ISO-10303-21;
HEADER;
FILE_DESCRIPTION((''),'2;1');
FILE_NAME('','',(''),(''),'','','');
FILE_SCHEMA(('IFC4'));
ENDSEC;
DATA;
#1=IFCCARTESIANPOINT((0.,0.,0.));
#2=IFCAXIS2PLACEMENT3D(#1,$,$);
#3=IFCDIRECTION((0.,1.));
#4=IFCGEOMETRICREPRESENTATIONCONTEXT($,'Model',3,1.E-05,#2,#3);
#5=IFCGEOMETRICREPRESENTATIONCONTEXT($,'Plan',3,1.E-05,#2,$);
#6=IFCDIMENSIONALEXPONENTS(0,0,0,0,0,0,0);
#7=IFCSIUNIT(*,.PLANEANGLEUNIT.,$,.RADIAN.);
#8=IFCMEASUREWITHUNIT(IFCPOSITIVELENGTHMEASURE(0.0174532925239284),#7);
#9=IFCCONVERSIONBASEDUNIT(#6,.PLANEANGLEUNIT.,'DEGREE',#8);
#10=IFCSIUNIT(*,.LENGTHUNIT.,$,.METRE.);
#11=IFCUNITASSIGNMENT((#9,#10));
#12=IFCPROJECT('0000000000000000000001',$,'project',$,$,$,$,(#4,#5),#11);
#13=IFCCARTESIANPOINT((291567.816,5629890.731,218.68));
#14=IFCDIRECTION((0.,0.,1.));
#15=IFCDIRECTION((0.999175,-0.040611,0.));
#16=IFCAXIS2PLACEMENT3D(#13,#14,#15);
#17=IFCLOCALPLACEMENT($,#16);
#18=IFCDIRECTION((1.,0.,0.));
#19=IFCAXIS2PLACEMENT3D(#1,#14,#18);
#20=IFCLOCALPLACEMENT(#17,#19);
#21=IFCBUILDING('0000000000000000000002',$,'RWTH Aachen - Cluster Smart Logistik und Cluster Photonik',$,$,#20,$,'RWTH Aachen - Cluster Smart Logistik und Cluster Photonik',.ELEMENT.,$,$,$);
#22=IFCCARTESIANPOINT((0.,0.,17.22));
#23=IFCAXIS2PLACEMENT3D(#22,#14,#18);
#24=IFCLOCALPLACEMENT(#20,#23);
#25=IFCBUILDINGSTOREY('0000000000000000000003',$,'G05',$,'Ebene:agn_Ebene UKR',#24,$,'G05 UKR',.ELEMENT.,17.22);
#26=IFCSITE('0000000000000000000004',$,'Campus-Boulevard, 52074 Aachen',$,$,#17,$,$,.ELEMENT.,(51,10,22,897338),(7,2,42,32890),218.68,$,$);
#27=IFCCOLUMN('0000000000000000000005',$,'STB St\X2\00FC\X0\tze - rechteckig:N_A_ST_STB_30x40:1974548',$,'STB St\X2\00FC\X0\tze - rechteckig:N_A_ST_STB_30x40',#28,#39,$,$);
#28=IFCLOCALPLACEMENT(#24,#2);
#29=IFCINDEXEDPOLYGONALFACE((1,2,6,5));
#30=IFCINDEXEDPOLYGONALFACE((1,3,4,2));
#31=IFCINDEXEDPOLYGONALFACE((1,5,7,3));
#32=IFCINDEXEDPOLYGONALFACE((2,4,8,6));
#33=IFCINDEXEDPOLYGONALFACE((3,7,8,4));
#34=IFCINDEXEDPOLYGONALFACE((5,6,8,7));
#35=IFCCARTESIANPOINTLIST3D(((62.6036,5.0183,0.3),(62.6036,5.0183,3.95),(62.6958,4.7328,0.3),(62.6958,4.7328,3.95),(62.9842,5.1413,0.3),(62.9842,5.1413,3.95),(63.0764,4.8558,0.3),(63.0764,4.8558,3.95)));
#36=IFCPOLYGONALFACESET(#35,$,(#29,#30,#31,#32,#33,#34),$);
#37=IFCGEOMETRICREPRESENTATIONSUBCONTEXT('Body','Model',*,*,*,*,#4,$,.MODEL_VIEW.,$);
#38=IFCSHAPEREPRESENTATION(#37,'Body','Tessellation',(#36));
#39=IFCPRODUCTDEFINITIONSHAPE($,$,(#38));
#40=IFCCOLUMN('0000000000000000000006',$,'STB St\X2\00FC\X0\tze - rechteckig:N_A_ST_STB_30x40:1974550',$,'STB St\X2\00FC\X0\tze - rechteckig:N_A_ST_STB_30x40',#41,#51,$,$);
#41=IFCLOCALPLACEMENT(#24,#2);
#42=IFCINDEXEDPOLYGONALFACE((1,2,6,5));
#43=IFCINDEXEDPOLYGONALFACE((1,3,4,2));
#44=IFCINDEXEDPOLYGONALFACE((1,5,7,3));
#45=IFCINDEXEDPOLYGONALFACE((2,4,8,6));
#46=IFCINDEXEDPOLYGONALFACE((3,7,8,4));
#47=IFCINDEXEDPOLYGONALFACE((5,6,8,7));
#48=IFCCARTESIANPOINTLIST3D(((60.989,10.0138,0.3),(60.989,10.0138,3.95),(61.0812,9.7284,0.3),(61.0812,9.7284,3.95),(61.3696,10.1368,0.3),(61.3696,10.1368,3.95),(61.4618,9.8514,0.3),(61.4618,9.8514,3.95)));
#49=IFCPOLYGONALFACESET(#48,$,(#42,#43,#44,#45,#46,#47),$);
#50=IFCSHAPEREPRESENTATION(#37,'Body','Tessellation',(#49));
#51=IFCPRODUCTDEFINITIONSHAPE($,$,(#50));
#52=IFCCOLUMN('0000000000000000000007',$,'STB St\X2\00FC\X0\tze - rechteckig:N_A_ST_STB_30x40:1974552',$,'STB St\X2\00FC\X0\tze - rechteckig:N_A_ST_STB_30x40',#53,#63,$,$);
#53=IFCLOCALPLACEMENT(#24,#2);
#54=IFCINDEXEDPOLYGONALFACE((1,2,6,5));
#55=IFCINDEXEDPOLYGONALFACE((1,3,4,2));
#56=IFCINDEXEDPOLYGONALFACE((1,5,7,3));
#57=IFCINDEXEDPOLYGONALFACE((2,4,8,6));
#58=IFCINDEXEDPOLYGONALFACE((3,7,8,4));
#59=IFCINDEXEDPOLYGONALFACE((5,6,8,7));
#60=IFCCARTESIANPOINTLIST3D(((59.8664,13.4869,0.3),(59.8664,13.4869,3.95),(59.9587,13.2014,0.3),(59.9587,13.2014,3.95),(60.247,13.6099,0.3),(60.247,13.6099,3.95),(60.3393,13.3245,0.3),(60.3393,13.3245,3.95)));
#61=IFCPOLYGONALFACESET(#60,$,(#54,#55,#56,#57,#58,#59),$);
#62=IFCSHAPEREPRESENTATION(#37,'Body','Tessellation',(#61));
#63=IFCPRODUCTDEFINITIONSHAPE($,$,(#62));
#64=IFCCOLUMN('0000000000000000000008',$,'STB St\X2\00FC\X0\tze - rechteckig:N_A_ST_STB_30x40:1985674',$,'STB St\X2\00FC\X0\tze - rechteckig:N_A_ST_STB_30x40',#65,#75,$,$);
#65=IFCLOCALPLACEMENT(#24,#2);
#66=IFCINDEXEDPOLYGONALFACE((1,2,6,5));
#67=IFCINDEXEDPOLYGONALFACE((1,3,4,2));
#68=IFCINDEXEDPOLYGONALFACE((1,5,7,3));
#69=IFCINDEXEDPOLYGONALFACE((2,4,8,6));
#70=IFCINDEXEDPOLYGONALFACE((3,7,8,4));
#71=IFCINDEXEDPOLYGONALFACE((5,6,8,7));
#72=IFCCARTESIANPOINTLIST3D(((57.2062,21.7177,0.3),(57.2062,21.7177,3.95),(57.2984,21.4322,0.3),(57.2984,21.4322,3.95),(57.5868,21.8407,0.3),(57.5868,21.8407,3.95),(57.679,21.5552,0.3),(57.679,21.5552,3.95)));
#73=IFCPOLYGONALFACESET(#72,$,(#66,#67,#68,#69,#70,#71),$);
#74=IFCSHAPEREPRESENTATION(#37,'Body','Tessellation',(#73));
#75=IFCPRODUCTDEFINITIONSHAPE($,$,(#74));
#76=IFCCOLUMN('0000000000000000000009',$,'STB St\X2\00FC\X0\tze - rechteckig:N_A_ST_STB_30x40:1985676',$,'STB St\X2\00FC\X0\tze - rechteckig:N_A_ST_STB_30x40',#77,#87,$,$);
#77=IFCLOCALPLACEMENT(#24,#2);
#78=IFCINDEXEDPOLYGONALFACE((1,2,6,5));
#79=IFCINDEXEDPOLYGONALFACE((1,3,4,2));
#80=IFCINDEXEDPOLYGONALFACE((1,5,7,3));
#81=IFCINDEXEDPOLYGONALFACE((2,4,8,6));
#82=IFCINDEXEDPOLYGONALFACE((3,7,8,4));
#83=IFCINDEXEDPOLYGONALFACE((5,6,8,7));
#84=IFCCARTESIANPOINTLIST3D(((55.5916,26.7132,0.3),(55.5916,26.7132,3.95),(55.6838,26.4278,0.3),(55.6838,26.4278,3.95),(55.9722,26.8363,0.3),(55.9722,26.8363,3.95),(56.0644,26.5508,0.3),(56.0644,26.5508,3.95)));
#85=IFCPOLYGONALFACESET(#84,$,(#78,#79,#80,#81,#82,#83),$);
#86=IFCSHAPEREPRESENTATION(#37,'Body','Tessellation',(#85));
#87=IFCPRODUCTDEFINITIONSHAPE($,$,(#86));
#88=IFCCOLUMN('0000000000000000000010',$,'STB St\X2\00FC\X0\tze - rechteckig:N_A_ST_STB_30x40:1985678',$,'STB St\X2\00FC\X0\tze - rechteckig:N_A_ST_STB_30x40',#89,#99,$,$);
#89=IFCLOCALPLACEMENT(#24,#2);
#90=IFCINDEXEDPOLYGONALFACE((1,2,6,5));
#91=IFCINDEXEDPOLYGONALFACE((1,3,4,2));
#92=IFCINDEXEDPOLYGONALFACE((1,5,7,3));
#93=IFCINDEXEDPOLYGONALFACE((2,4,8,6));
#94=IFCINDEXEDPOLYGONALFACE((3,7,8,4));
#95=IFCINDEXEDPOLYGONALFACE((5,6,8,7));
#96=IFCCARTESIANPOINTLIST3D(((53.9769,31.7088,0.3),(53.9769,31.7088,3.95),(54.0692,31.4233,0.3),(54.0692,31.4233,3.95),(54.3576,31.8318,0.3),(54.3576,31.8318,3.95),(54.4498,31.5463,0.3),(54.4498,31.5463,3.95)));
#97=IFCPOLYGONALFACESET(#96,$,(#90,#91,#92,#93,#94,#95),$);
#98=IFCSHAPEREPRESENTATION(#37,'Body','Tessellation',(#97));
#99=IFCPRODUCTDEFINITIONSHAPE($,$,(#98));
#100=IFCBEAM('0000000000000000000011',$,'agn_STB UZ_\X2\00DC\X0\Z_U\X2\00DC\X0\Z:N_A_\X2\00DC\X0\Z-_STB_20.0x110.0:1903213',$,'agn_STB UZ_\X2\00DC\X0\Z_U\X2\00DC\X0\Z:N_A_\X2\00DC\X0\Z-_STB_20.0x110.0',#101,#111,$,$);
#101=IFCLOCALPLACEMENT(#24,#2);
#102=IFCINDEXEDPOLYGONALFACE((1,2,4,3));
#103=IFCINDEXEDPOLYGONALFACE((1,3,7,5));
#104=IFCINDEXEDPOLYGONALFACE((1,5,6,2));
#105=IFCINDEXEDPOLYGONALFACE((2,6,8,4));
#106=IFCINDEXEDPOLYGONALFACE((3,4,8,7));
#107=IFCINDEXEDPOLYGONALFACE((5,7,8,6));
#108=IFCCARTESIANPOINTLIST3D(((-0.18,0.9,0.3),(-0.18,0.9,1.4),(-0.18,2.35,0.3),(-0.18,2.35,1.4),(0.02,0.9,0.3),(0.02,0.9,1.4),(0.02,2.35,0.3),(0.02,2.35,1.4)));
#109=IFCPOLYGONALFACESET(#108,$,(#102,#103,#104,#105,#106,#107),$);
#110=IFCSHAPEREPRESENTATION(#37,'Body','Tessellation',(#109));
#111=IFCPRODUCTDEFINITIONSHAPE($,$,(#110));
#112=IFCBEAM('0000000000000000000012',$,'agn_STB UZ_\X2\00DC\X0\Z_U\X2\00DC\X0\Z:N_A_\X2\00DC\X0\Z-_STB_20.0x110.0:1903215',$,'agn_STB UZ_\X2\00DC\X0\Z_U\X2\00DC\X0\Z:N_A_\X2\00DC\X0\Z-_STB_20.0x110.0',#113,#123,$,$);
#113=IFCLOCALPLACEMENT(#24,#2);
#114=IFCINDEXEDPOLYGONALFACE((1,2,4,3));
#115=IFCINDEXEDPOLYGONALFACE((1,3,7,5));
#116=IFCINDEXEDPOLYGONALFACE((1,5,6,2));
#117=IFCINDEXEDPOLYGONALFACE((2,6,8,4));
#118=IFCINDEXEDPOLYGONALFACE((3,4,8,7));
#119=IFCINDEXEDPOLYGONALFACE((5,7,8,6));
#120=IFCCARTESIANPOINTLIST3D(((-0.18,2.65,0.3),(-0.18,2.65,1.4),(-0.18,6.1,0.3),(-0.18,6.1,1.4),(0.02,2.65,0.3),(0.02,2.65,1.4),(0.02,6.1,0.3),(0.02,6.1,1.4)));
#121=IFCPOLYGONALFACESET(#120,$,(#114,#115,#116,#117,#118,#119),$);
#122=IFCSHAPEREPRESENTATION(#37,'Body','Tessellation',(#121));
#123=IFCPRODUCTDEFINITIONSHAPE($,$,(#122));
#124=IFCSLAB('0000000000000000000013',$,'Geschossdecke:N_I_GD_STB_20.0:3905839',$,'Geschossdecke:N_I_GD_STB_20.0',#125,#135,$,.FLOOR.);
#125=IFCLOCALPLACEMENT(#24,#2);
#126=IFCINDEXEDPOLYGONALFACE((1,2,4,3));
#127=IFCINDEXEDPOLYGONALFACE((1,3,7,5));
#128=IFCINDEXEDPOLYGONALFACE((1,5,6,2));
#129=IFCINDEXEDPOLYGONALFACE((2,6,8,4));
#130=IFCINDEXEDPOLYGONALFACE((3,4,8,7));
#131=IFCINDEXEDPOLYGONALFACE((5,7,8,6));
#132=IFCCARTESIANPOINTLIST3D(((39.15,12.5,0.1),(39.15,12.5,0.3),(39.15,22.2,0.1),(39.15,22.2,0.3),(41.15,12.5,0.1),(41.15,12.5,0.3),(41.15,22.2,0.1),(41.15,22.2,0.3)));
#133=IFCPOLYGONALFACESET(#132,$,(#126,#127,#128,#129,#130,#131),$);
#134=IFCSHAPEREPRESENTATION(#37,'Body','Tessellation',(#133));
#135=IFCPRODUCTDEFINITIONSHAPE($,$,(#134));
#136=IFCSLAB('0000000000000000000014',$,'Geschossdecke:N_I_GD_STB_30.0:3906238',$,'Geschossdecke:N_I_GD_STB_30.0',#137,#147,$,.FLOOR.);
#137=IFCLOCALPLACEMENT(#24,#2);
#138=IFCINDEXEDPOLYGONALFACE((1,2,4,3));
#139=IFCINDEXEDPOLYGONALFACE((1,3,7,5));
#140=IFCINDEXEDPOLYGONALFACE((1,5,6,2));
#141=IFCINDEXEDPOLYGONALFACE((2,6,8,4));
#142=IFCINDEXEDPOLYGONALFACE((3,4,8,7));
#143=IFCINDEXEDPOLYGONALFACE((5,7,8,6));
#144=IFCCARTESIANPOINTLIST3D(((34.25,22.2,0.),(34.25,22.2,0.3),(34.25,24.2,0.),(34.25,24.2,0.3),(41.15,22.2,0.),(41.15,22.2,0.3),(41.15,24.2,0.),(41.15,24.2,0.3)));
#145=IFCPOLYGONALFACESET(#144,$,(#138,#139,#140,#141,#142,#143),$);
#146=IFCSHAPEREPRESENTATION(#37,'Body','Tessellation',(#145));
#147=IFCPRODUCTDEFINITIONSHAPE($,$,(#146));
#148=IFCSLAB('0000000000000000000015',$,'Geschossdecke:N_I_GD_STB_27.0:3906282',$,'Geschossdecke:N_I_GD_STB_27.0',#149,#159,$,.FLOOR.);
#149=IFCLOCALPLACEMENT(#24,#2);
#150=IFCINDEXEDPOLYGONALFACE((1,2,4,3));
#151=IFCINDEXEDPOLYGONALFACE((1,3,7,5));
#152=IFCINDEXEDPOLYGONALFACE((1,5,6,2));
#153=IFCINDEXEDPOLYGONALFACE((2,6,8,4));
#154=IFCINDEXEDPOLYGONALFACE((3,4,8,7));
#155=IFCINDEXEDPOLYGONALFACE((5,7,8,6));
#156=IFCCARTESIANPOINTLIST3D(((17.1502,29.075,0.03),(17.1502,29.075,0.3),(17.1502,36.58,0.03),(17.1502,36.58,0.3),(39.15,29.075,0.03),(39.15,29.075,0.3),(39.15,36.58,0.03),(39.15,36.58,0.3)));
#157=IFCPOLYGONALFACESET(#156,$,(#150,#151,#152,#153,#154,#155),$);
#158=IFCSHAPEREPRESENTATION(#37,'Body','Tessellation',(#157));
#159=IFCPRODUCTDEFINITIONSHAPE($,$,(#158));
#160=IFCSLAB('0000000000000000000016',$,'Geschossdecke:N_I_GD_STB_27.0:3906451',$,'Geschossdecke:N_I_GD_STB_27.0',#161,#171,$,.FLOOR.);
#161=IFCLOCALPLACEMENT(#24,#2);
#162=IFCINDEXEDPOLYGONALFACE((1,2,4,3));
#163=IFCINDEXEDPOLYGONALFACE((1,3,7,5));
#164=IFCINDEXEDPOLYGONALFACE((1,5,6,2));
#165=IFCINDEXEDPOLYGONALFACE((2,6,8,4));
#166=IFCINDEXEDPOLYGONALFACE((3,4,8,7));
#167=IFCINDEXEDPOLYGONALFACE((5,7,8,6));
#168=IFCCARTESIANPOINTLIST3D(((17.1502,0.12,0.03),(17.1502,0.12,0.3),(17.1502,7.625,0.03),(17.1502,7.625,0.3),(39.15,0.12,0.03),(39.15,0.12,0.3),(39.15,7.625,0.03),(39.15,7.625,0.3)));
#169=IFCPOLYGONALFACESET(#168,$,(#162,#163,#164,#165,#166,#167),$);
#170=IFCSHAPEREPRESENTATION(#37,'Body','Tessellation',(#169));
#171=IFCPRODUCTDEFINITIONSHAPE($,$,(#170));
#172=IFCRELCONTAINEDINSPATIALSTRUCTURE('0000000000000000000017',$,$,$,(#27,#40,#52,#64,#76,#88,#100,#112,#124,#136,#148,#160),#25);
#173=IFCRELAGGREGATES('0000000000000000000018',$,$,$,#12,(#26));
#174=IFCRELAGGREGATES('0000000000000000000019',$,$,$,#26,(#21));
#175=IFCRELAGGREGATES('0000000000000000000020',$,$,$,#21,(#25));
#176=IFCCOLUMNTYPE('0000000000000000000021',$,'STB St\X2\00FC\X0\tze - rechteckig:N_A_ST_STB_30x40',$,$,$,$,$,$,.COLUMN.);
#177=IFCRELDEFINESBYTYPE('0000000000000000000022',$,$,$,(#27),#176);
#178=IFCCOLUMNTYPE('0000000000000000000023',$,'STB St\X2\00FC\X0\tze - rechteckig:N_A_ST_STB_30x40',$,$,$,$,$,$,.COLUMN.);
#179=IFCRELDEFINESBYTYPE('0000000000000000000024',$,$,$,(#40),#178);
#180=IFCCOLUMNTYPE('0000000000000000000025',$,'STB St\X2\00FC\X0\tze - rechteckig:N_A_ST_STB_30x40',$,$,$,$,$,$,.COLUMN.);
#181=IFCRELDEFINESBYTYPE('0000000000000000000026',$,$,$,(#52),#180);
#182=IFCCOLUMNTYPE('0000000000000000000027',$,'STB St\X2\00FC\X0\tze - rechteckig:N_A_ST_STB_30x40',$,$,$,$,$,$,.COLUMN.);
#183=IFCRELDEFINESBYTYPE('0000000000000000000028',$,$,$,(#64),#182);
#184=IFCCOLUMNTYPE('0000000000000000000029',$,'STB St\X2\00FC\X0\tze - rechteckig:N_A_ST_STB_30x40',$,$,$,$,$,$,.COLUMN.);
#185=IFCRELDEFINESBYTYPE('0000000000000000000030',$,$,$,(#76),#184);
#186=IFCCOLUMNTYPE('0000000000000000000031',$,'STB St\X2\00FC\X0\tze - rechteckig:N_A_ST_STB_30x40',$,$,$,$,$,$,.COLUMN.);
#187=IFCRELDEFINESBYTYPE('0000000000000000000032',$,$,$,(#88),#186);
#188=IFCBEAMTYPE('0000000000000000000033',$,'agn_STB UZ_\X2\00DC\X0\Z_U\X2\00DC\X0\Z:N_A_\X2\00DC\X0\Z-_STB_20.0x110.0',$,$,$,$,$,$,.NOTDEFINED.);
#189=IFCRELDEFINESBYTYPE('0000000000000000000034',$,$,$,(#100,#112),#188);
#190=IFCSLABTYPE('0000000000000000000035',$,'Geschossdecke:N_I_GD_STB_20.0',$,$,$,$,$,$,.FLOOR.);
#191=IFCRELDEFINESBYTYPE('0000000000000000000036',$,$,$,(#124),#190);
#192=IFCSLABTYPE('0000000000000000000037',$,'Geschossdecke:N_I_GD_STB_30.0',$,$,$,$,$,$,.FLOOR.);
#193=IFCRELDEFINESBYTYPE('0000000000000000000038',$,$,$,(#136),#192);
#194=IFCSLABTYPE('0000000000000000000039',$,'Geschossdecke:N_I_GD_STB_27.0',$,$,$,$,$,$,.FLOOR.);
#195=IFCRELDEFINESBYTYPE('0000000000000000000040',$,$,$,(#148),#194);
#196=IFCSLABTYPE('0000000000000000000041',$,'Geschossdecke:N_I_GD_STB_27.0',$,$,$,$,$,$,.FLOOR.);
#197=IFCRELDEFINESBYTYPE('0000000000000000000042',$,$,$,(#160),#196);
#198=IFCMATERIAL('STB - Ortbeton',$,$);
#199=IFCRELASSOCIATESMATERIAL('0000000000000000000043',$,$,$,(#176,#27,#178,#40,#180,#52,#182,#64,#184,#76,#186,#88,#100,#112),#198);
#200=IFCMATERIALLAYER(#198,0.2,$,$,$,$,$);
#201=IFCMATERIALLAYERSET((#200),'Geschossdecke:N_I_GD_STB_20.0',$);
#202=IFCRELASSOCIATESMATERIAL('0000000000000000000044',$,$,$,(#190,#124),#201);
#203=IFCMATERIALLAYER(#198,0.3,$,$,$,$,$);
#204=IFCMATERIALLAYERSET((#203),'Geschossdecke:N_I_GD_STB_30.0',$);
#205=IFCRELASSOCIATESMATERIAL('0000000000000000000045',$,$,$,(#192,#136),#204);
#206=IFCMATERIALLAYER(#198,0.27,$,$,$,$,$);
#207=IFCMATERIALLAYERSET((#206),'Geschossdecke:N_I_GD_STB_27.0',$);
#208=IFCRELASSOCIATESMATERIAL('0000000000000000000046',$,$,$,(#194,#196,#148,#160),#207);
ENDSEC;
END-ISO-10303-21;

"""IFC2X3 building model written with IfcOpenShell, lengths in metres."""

from ifc_helpers import new_model, entity, si_unit, converted_unit, direction, frame, frame_2d, origin, origin_with_axes, origin_2d_with_axis, place, context, subcontext, project, spatial, rectangle, extrude, source, transform, mapped, material, layer, layer_set, layer_usage, type_object, element, save


model = new_model("IFC2X3")

# Units and contexts
model_context = context("Model", 3, precision=1e-05, world=origin(), true_north=direction((0.0, 1.0)))
plan_context = context("Plan", 3, precision=1e-05, world=origin())
body_context = subcontext(model_context, "Body", "Model", "MODEL_VIEW")
ifc_project = project(units=[converted_unit("PLANEANGLEUNIT", "DEGREE", entity("IfcPositiveLengthMeasure", 0.0174532925239284), si_unit("PLANEANGLEUNIT", "RADIAN"), dimensions=[0, 0, 0, 0, 0, 0, 0]), si_unit("LENGTHUNIT", "METRE")], contexts=[model_context, plan_context])

# Site, building, storey
site_placement = place(None, frame((291567.816, 5629890.731, 218.68), z_axis=(0.0, 0.0, 1.0), x_axis=(0.999175, -0.040611, 0.0)))
site = spatial("IfcSite", under=ifc_project, at=site_placement, Name="Campus-Boulevard, 52074 Aachen", CompositionType="ELEMENT", RefLatitude=(51, 10, 22, 897338), RefLongitude=(7, 2, 42, 32890), RefElevation=218.68)
building_placement = place(site_placement, origin_with_axes())
building = spatial("IfcBuilding", under=site, at=building_placement, Name="RWTH Aachen - Cluster Smart Logistik und Cluster Photonik", LongName="RWTH Aachen - Cluster Smart Logistik und Cluster Photonik", CompositionType="ELEMENT")
storey_placement = place(building_placement, frame((0.0, 0.0, 17.22), z_axis=(0.0, 0.0, 1.0), x_axis=(1.0, 0.0, 0.0)))
storey = spatial("IfcBuildingStorey", under=building, at=storey_placement, Name="G05", ObjectType="Ebene:agn_Ebene UKR", LongName="G05 UKR", CompositionType="ELEMENT", Elevation=17.22)

# Columns
ifc_material_1 = material(Name="STB - Ortbeton")
column_type_1 = type_object("IfcColumnType", Name="STB Stütze - rechteckig:N_A_ST_STB_30x40", PredefinedType="COLUMN", material=ifc_material_1)
shared_shape_1 = source(origin(), body_context, "Body", "SweptSolid", [
    extrude(rectangle(XDim=0.3, YDim=0.4, at=frame_2d((0.0, 0.0), x_axis=(1.0, 0.0))), frame((62.84, 4.937, 17.52), z_axis=(0.0, 0.0, 1.0), x_axis=(-0.307544, 0.951534, 0.0)), (0.0, 0.0, 1.0), 3.65),
])
column_1_placement = place(storey_placement, frame((0.0, 0.0, -17.22), z_axis=(0.0, 0.0, 1.0), x_axis=(1.0, 0.0, 0.0)))
element("IfcColumn", 1, at=column_1_placement, inside=storey, type_object=column_type_1, material=ifc_material_1, Name="STB Stütze - rechteckig:N_A_ST_STB_30x40:1974548", ObjectType="STB Stütze - rechteckig:N_A_ST_STB_30x40", context=body_context, shape_type="MappedRepresentation", body=[
    mapped(shared_shape_1, transform((0.0, 0.0, 0.0), scale=1.0)),
])
column_type_2 = type_object("IfcColumnType", Name="STB Stütze - rechteckig:N_A_ST_STB_30x40", PredefinedType="COLUMN", material=ifc_material_1)
shared_shape_2 = source(origin(), body_context, "Body", "SweptSolid", [
    extrude(rectangle(XDim=0.3, YDim=0.4, at=frame_2d((0.0, 0.0), x_axis=(1.0, 0.0))), frame((61.2254, 9.9326, 17.52), z_axis=(0.0, 0.0, 1.0), x_axis=(-0.307544, 0.951534, 0.0)), (0.0, 0.0, 1.0), 3.65),
])
column_2_placement = place(storey_placement, frame((0.0, 0.0, -17.22), z_axis=(0.0, 0.0, 1.0), x_axis=(1.0, 0.0, 0.0)))
element("IfcColumn", 2, at=column_2_placement, inside=storey, type_object=column_type_2, material=ifc_material_1, Name="STB Stütze - rechteckig:N_A_ST_STB_30x40:1974550", ObjectType="STB Stütze - rechteckig:N_A_ST_STB_30x40", context=body_context, shape_type="MappedRepresentation", body=[
    mapped(shared_shape_2, transform((0.0, 0.0, 0.0), scale=1.0)),
])
column_type_3 = type_object("IfcColumnType", Name="STB Stütze - rechteckig:N_A_ST_STB_30x40", PredefinedType="COLUMN", material=ifc_material_1)
shared_shape_3 = source(origin(), body_context, "Body", "SweptSolid", [
    extrude(rectangle(XDim=0.3, YDim=0.4, at=frame_2d((0.0, 0.0), x_axis=(1.0, 0.0))), frame((60.1029, 13.4057, 17.52), z_axis=(0.0, 0.0, 1.0), x_axis=(-0.307544, 0.951534, 0.0)), (0.0, 0.0, 1.0), 3.65),
])
column_3_placement = place(storey_placement, frame((0.0, 0.0, -17.22), z_axis=(0.0, 0.0, 1.0), x_axis=(1.0, 0.0, 0.0)))
element("IfcColumn", 3, at=column_3_placement, inside=storey, type_object=column_type_3, material=ifc_material_1, Name="STB Stütze - rechteckig:N_A_ST_STB_30x40:1974552", ObjectType="STB Stütze - rechteckig:N_A_ST_STB_30x40", context=body_context, shape_type="MappedRepresentation", body=[
    mapped(shared_shape_3, transform((0.0, 0.0, 0.0), scale=1.0)),
])
column_type_4 = type_object("IfcColumnType", Name="STB Stütze - rechteckig:N_A_ST_STB_30x40", PredefinedType="COLUMN", material=ifc_material_1)
shared_shape_4 = source(origin(), body_context, "Body", "SweptSolid", [
    extrude(rectangle(XDim=0.3, YDim=0.4, at=origin_2d_with_axis()), frame((57.4426, 21.6365, 17.52), z_axis=(0.0, 0.0, 1.0), x_axis=(-0.307544, 0.951534, 0.0)), (0.0, 0.0, 1.0), 3.65),
])
column_4_placement = place(storey_placement, frame((0.0, 0.0, -17.22), z_axis=(0.0, 0.0, 1.0), x_axis=(1.0, 0.0, 0.0)))
element("IfcColumn", 4, at=column_4_placement, inside=storey, type_object=column_type_4, material=ifc_material_1, Name="STB Stütze - rechteckig:N_A_ST_STB_30x40:1985674", ObjectType="STB Stütze - rechteckig:N_A_ST_STB_30x40", context=body_context, shape_type="MappedRepresentation", body=[
    mapped(shared_shape_4, transform((0.0, 0.0, 0.0), scale=1.0)),
])
column_type_5 = type_object("IfcColumnType", Name="STB Stütze - rechteckig:N_A_ST_STB_30x40", PredefinedType="COLUMN", material=ifc_material_1)
shared_shape_5 = source(origin(), body_context, "Body", "SweptSolid", [
    extrude(rectangle(XDim=0.3, YDim=0.4, at=origin_2d_with_axis()), frame((55.828, 26.632, 17.52), z_axis=(0.0, 0.0, 1.0), x_axis=(-0.307544, 0.951534, 0.0)), (0.0, 0.0, 1.0), 3.65),
])
column_5_placement = place(storey_placement, frame((0.0, 0.0, -17.22), z_axis=(0.0, 0.0, 1.0), x_axis=(1.0, 0.0, 0.0)))
element("IfcColumn", 5, at=column_5_placement, inside=storey, type_object=column_type_5, material=ifc_material_1, Name="STB Stütze - rechteckig:N_A_ST_STB_30x40:1985676", ObjectType="STB Stütze - rechteckig:N_A_ST_STB_30x40", context=body_context, shape_type="MappedRepresentation", body=[
    mapped(shared_shape_5, transform((0.0, 0.0, 0.0), scale=1.0)),
])
column_type_6 = type_object("IfcColumnType", Name="STB Stütze - rechteckig:N_A_ST_STB_30x40", PredefinedType="COLUMN", material=ifc_material_1)
shared_shape_6 = source(origin(), body_context, "Body", "SweptSolid", [
    extrude(rectangle(XDim=0.3, YDim=0.4, at=origin_2d_with_axis()), frame((54.2134, 31.6276, 17.52), z_axis=(0.0, 0.0, 1.0), x_axis=(-0.307544, 0.951534, 0.0)), (0.0, 0.0, 1.0), 3.65),
])
column_6_placement = place(storey_placement, frame((0.0, 0.0, -17.22), z_axis=(0.0, 0.0, 1.0), x_axis=(1.0, 0.0, 0.0)))
element("IfcColumn", 6, at=column_6_placement, inside=storey, type_object=column_type_6, material=ifc_material_1, Name="STB Stütze - rechteckig:N_A_ST_STB_30x40:1985678", ObjectType="STB Stütze - rechteckig:N_A_ST_STB_30x40", context=body_context, shape_type="MappedRepresentation", body=[
    mapped(shared_shape_6, transform((0.0, 0.0, 0.0), scale=1.0)),
])

# Beams
beam_type_1 = type_object("IfcBeamType", Name="agn_STB UZ_ÜZ_UÜZ:N_A_ÜZ-_STB_20.0x110.0", PredefinedType="NOTDEFINED")
beam_1_placement = place(storey_placement, frame((-0.08, 2.35, 0.3), z_axis=(0.0, 0.0, 1.0), x_axis=(0.0, -1.0, 0.0)))
element("IfcBeam", 7, at=beam_1_placement, inside=storey, type_object=beam_type_1, material=ifc_material_1, Name="agn_STB UZ_ÜZ_UÜZ:N_A_ÜZ-_STB_20.0x110.0:1903213", ObjectType="agn_STB UZ_ÜZ_UÜZ:N_A_ÜZ-_STB_20.0x110.0", context=body_context, shape_type="SweptSolid", body=[
    extrude(rectangle(XDim=1.1, YDim=0.2, at=frame_2d((0.0, 0.0), x_axis=(1.0, 0.0))), frame((0.0, 0.0, 0.55), z_axis=(1.0, 0.0, 0.0), x_axis=(0.0, 0.0, -1.0)), (0.0, 0.0, 1.0), 1.45),
])
beam_2_placement = place(storey_placement, frame((-0.08, 6.1, 0.3), z_axis=(0.0, 0.0, 1.0), x_axis=(0.0, -1.0, 0.0)))
element("IfcBeam", 8, at=beam_2_placement, inside=storey, type_object=beam_type_1, material=ifc_material_1, Name="agn_STB UZ_ÜZ_UÜZ:N_A_ÜZ-_STB_20.0x110.0:1903215", ObjectType="agn_STB UZ_ÜZ_UÜZ:N_A_ÜZ-_STB_20.0x110.0", context=body_context, shape_type="SweptSolid", body=[
    extrude(rectangle(XDim=1.1, YDim=0.2, at=frame_2d((0.0, 0.0), x_axis=(1.0, 0.0))), frame((0.0, 0.0, 0.55), z_axis=(1.0, 0.0, 0.0), x_axis=(0.0, 0.0, -1.0)), (0.0, 0.0, 1.0), 3.45),
])

# Slabs
ifc_layer_1 = layer(ifc_material_1, 0.3)
ifc_layer_set_1 = layer_set([ifc_layer_1], Name="Geschossdecke:N_I_GD_STB_30.0")
ifc_layer_2 = layer(ifc_material_1, 0.2)
ifc_layer_set_2 = layer_set([ifc_layer_2], Name="Geschossdecke:N_I_GD_STB_20.0")
ifc_layer_usage_1 = layer_usage(ifc_layer_set_2, "AXIS3", "POSITIVE", 0.0)
slab_type_1 = type_object("IfcSlabType", Name="Geschossdecke:N_I_GD_STB_20.0", PredefinedType="FLOOR", material=ifc_layer_set_2)
slab_1_placement = place(storey_placement, origin_with_axes())
element("IfcSlab", 9, at=slab_1_placement, inside=storey, type_object=slab_type_1, material=ifc_layer_usage_1, Name="Geschossdecke:N_I_GD_STB_20.0:3905839", ObjectType="Geschossdecke:N_I_GD_STB_20.0", PredefinedType="FLOOR", context=body_context, shape_type="SweptSolid", body=[
    extrude(rectangle(XDim=9.7, YDim=2.0, at=frame_2d((0.0, 0.0), x_axis=(1.0, 0.0))), frame((40.15, 17.35, 0.3), z_axis=(0.0, 0.0, -1.0), x_axis=(0.0, 1.0, 0.0)), (0.0, 0.0, 1.0), 0.2),
])
ifc_layer_usage_2 = layer_usage(ifc_layer_set_1, "AXIS3", "POSITIVE", 0.0)
slab_type_2 = type_object("IfcSlabType", Name="Geschossdecke:N_I_GD_STB_30.0", PredefinedType="FLOOR", material=ifc_layer_set_1)
slab_2_placement = place(storey_placement, origin_with_axes())
element("IfcSlab", 10, at=slab_2_placement, inside=storey, type_object=slab_type_2, material=ifc_layer_usage_2, Name="Geschossdecke:N_I_GD_STB_30.0:3906238", ObjectType="Geschossdecke:N_I_GD_STB_30.0", PredefinedType="FLOOR", context=body_context, shape_type="SweptSolid", body=[
    extrude(rectangle(XDim=2.0, YDim=6.9, at=origin_2d_with_axis()), frame((37.7, 23.2, 0.3), z_axis=(0.0, 0.0, -1.0), x_axis=(0.0, 1.0, 0.0)), (0.0, 0.0, 1.0), 0.3),
])
ifc_layer_3 = layer(ifc_material_1, 0.27)
ifc_layer_set_3 = layer_set([ifc_layer_3], Name="Geschossdecke:N_I_GD_STB_27.0")
ifc_layer_usage_3 = layer_usage(ifc_layer_set_3, "AXIS3", "POSITIVE", 0.0)
slab_type_3 = type_object("IfcSlabType", Name="Geschossdecke:N_I_GD_STB_27.0", PredefinedType="FLOOR", material=ifc_layer_set_3)
slab_3_placement = place(storey_placement, origin_with_axes())
element("IfcSlab", 11, at=slab_3_placement, inside=storey, type_object=slab_type_3, material=ifc_layer_usage_3, Name="Geschossdecke:N_I_GD_STB_27.0:3906282", ObjectType="Geschossdecke:N_I_GD_STB_27.0", PredefinedType="FLOOR", context=body_context, shape_type="SweptSolid", body=[
    extrude(rectangle(XDim=7.505, YDim=21.9998, at=frame_2d((0.0, 0.0), x_axis=(1.0, 0.0))), frame((28.1501, 32.8275, 0.3), z_axis=(0.0, 0.0, -1.0), x_axis=(0.0, 1.0, 0.0)), (0.0, 0.0, 1.0), 0.27),
])
ifc_layer_usage_4 = layer_usage(ifc_layer_set_3, "AXIS3", "POSITIVE", 0.0)
slab_type_4 = type_object("IfcSlabType", Name="Geschossdecke:N_I_GD_STB_27.0", PredefinedType="FLOOR", material=ifc_layer_set_3)
slab_4_placement = place(storey_placement, origin_with_axes())
element("IfcSlab", 12, at=slab_4_placement, inside=storey, type_object=slab_type_4, material=ifc_layer_usage_4, Name="Geschossdecke:N_I_GD_STB_27.0:3906451", ObjectType="Geschossdecke:N_I_GD_STB_27.0", PredefinedType="FLOOR", context=body_context, shape_type="SweptSolid", body=[
    extrude(rectangle(XDim=7.505, YDim=21.9998, at=frame_2d((0.0, 0.0), x_axis=(1.0, 0.0))), frame((28.1501, 3.8725, 0.3), z_axis=(0.0, 0.0, -1.0), x_axis=(0.0, 1.0, 0.0)), (0.0, 0.0, 1.0), 0.27),
])

save(model, "model.ifc")
